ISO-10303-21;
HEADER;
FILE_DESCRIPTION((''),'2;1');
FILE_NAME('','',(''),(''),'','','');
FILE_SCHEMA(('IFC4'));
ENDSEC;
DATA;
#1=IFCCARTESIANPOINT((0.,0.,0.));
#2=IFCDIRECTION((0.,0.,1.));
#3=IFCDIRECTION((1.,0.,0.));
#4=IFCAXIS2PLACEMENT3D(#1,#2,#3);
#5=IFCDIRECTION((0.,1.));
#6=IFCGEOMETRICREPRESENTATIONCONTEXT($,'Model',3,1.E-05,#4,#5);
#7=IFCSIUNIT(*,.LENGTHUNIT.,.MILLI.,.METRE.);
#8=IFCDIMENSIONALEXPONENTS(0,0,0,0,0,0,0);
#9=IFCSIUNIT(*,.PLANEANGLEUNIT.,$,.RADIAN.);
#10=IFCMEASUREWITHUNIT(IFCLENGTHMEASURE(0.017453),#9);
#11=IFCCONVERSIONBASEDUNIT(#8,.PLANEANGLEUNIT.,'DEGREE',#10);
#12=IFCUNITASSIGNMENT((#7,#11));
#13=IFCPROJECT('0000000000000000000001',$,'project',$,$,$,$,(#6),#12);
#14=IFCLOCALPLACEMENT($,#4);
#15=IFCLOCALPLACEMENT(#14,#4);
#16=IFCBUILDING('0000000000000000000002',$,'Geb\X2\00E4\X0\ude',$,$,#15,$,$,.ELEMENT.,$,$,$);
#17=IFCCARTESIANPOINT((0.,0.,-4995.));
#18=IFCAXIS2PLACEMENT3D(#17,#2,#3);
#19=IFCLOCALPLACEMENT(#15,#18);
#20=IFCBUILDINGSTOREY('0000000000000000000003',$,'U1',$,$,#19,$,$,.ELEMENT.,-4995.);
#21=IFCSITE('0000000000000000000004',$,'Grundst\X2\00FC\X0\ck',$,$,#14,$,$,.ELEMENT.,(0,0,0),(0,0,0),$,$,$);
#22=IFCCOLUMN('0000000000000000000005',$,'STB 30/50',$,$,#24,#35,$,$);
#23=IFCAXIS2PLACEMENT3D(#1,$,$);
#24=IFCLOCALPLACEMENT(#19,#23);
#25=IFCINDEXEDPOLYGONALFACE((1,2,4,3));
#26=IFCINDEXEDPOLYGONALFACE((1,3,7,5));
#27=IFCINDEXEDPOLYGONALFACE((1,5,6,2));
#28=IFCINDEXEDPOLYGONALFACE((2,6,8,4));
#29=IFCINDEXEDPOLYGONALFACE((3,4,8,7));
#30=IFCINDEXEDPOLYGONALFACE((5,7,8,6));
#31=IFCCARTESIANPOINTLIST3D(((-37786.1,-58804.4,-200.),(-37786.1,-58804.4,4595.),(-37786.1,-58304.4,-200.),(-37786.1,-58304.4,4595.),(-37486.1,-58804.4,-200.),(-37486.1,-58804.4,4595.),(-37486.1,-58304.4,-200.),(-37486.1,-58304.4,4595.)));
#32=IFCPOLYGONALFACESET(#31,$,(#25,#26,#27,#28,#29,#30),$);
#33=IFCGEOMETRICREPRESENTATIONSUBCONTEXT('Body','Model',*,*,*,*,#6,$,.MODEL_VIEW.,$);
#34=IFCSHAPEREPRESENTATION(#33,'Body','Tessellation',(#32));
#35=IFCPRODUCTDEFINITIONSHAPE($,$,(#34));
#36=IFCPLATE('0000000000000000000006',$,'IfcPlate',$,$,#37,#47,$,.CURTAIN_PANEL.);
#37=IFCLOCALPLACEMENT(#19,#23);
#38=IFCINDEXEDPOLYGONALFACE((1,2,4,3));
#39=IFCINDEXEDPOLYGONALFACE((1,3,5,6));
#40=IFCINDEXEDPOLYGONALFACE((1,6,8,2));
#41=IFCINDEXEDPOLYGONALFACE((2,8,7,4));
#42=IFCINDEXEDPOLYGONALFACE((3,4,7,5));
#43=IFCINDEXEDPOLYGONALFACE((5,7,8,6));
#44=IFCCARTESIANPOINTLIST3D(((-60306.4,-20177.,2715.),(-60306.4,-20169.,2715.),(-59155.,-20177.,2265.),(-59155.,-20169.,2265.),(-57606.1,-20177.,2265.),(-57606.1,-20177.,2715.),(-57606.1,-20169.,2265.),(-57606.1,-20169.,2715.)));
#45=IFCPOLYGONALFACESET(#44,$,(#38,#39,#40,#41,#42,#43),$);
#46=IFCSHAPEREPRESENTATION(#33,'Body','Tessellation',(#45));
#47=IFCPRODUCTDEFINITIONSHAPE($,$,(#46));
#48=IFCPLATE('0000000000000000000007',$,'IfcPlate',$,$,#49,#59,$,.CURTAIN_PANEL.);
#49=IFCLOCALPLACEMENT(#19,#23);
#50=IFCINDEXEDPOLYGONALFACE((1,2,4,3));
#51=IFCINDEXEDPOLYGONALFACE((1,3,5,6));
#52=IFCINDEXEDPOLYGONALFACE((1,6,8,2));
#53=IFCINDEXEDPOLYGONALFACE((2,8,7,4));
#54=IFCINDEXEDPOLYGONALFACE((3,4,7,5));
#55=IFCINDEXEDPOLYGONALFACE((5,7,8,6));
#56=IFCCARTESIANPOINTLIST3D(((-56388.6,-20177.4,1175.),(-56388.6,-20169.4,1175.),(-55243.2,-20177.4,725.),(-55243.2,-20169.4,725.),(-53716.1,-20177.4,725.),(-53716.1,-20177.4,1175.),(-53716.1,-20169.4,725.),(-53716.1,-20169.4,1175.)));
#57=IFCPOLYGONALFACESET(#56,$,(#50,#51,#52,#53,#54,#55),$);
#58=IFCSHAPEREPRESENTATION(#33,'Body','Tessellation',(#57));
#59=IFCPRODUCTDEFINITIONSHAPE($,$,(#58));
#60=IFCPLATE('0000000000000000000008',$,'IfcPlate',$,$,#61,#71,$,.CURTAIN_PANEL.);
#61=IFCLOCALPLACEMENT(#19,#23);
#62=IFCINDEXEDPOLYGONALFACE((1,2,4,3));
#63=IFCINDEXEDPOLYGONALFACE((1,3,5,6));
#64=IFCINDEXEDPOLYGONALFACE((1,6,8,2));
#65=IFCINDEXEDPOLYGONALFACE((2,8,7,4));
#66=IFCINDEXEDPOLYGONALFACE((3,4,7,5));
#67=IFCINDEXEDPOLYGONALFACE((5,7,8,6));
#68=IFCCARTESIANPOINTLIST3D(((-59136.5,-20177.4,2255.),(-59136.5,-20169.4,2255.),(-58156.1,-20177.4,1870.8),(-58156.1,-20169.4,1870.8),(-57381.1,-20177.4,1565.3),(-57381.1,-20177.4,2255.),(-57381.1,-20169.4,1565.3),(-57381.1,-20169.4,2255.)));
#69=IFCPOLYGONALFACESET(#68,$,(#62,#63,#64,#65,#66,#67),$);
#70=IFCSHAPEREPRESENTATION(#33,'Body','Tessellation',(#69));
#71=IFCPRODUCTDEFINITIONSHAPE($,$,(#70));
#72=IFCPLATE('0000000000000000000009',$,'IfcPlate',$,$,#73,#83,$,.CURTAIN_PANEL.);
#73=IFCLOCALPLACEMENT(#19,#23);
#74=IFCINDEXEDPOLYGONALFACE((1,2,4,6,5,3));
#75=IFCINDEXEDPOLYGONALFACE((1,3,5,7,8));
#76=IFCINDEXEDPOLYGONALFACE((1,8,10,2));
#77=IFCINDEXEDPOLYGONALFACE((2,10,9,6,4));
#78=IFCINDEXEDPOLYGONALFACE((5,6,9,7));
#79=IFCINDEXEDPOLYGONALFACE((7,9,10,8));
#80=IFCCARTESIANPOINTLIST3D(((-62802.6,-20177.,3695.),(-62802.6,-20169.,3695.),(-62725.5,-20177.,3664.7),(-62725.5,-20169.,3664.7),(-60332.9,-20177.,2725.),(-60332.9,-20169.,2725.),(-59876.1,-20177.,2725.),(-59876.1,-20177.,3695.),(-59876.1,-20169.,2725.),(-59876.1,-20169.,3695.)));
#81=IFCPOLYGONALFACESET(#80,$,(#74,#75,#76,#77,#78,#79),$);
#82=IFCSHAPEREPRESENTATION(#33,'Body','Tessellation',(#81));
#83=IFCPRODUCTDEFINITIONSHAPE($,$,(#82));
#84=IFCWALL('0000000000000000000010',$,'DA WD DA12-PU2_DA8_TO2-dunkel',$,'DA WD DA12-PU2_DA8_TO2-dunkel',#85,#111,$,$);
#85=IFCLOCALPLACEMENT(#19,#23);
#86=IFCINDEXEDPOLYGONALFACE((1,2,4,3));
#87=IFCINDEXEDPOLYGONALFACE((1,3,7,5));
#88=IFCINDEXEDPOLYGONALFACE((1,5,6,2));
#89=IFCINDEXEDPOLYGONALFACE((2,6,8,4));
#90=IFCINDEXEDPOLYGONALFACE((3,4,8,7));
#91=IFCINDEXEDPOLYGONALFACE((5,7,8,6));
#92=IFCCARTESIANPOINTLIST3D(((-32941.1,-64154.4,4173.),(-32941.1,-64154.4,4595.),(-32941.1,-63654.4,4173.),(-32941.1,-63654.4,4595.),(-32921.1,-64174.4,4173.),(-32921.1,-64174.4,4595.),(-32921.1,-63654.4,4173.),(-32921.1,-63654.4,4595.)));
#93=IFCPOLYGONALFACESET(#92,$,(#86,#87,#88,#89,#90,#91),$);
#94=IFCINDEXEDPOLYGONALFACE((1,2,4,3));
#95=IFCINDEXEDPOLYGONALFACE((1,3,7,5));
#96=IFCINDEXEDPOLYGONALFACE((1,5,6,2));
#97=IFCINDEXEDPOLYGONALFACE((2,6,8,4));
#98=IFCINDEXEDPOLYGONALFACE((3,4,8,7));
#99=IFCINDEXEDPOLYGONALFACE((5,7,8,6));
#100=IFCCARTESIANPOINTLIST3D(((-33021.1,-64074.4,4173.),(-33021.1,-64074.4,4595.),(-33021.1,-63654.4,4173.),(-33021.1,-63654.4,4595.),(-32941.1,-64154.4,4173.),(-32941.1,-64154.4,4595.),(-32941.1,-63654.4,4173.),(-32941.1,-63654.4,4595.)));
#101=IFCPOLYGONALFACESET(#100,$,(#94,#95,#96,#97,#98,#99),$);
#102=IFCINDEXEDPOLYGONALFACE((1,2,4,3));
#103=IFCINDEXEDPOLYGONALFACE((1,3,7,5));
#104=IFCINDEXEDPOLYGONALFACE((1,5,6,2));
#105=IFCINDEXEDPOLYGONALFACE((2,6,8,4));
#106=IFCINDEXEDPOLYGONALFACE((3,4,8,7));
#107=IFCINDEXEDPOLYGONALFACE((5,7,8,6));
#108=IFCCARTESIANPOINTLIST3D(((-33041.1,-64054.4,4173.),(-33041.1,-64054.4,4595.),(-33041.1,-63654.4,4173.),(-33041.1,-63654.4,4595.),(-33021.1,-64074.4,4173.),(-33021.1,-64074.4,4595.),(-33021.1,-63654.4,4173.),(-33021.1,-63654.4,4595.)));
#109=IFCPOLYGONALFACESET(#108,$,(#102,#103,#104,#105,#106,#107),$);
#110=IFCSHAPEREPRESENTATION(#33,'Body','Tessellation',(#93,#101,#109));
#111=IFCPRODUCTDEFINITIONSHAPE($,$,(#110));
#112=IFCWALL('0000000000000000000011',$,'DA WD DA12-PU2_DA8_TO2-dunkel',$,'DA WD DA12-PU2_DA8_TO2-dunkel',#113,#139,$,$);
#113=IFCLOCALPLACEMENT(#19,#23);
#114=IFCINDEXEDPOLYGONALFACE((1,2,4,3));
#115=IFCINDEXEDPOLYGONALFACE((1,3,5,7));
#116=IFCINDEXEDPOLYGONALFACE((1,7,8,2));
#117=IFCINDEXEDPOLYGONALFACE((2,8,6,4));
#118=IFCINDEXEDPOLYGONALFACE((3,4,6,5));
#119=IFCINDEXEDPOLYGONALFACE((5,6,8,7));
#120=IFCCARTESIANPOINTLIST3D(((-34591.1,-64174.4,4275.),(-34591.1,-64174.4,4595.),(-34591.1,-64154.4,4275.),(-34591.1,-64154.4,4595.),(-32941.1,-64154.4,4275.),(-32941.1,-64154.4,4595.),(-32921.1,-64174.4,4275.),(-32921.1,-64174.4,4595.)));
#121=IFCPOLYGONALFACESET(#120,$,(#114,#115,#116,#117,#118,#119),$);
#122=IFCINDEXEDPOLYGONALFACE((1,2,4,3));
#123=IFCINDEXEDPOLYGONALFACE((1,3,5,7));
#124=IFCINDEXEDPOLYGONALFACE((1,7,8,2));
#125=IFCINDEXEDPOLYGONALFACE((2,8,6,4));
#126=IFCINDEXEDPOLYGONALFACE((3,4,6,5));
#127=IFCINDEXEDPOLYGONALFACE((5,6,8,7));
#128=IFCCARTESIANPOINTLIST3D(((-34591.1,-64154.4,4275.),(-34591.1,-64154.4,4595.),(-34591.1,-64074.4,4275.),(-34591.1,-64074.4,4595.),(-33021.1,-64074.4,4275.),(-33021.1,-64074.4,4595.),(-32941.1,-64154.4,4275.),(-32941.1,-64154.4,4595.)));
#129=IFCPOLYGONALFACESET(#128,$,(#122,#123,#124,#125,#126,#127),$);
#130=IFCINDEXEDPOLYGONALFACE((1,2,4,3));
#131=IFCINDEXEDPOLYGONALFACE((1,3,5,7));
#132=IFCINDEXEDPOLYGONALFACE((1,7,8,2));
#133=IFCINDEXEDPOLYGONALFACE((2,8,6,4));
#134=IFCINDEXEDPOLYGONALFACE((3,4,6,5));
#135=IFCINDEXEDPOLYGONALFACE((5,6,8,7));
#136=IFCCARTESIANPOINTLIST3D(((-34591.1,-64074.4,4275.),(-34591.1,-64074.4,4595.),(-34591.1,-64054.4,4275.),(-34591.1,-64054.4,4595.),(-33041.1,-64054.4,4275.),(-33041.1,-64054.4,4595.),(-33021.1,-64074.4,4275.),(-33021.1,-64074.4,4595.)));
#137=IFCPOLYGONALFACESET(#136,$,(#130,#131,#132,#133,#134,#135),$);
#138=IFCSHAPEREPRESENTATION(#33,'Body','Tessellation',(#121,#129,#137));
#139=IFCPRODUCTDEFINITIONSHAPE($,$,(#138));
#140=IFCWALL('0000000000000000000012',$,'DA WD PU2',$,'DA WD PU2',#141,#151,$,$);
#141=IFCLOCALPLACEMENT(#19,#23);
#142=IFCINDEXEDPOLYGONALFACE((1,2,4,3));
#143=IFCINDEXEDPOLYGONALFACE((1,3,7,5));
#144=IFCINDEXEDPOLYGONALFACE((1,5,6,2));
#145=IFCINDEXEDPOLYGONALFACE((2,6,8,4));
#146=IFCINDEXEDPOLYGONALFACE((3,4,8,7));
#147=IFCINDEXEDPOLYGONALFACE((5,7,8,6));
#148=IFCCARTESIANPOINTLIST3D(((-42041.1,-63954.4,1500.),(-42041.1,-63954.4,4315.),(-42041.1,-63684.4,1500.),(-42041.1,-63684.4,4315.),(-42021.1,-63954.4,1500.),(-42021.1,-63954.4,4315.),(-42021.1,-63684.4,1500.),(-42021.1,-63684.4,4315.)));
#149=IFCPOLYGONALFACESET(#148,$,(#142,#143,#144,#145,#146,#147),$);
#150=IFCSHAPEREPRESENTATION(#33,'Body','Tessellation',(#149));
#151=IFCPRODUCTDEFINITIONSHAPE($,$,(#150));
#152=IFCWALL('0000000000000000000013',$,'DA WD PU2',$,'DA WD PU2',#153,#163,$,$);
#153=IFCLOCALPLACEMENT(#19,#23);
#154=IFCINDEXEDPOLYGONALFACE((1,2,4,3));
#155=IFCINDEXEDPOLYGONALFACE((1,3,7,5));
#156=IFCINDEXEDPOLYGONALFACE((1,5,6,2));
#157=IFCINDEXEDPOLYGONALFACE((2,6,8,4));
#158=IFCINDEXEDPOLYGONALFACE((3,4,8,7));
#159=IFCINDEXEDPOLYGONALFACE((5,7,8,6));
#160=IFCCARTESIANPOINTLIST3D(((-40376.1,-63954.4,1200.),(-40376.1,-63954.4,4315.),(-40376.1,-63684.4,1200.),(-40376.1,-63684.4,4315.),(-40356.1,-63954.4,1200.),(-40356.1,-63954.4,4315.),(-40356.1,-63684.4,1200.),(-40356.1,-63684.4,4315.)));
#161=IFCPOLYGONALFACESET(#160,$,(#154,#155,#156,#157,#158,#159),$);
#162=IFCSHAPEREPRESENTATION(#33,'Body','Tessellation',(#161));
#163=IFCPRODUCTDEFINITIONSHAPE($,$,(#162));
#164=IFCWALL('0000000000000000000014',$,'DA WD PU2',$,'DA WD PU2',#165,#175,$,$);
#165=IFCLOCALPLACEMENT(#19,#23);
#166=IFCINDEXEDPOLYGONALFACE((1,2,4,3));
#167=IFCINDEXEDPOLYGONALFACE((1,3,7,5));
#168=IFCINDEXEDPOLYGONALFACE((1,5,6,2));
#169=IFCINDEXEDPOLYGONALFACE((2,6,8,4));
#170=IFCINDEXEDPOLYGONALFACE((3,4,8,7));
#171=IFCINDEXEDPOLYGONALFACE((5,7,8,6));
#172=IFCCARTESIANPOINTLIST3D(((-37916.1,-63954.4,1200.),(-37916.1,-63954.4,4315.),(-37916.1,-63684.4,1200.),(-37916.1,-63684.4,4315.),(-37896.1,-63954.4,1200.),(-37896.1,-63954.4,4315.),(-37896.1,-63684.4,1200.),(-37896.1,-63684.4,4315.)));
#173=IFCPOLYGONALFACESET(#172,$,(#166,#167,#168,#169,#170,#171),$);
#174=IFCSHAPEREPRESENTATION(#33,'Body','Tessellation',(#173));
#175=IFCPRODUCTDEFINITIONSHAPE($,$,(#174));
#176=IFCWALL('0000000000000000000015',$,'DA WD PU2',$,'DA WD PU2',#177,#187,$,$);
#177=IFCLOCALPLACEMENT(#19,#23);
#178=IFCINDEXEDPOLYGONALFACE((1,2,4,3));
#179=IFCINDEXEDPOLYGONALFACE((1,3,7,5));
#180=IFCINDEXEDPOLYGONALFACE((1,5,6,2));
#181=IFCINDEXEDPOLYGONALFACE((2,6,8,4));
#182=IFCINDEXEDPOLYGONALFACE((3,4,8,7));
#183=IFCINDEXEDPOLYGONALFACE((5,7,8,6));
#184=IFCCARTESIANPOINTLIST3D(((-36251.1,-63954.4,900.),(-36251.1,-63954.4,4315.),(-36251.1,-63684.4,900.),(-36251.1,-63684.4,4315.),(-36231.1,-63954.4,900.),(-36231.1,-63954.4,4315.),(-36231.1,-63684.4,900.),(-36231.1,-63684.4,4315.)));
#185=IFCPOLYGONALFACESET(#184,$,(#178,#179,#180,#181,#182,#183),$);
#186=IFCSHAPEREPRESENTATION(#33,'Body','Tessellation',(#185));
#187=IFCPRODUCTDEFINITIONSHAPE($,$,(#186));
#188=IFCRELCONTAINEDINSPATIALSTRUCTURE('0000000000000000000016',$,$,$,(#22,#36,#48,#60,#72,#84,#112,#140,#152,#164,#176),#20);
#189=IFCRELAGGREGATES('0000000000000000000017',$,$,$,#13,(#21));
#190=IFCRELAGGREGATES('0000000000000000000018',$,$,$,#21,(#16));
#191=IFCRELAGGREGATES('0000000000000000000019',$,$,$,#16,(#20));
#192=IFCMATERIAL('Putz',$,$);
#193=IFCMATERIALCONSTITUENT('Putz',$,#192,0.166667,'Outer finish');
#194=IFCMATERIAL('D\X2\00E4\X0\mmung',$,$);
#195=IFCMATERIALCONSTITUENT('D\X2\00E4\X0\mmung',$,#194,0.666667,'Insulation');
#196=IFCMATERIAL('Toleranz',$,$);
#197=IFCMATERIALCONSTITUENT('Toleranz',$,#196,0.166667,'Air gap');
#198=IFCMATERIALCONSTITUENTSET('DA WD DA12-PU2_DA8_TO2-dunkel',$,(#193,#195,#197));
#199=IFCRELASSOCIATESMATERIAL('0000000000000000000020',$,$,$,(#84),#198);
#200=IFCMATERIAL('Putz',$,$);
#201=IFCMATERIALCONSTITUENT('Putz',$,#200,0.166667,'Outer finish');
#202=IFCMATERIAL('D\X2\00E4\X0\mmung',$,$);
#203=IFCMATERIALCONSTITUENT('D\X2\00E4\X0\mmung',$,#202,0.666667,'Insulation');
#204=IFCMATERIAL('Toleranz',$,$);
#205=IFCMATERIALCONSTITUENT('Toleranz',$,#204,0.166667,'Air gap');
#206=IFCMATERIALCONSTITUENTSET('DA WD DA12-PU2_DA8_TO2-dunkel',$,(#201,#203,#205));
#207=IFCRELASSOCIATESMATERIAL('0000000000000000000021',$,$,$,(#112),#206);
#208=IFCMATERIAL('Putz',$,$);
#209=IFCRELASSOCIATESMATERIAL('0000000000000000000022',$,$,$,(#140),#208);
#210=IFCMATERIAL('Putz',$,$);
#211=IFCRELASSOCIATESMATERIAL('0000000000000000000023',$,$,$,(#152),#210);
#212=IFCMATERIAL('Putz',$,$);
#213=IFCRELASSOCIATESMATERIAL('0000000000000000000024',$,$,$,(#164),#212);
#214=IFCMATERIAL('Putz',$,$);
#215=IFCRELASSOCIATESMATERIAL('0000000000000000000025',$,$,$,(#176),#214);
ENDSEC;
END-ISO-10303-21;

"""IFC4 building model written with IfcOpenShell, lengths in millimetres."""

from ifc_helpers import new_model, entity, si_unit, converted_unit, direction, frame, origin_with_axes, place, context, subcontext, project, spatial, line, indexed_curve, outline, extrude, material, constituent, constituent_set, element, save


model = new_model("IFC4")

# Units and contexts
model_context = context("Model", 3, precision=1e-05, world=origin_with_axes(), true_north=direction((0.0, 1.0)))
body_context = subcontext(model_context, "Body", "Model", "MODEL_VIEW")
ifc_project = project(units=[si_unit("LENGTHUNIT", "METRE", prefix="MILLI"), converted_unit("PLANEANGLEUNIT", "DEGREE", entity("IfcLengthMeasure", 0.017453), si_unit("PLANEANGLEUNIT", "RADIAN"), dimensions=[0, 0, 0, 0, 0, 0, 0])], contexts=[model_context])

# Site, building, storey
site_placement = place(None, origin_with_axes())
site = spatial("IfcSite", under=ifc_project, at=site_placement, Name="Grundstück", CompositionType="ELEMENT", RefLatitude=(0, 0, 0), RefLongitude=(0, 0, 0))
building_placement = place(site_placement, origin_with_axes())
building = spatial("IfcBuilding", under=site, at=building_placement, Name="Gebäude", CompositionType="ELEMENT")
storey_placement = place(building_placement, frame((0.0, 0.0, -4995.0), z_axis=(0.0, 0.0, 1.0), x_axis=(1.0, 0.0, 0.0)))
storey = spatial("IfcBuildingStorey", under=building, at=storey_placement, Name="U1", CompositionType="ELEMENT", Elevation=-4995.0)

# Column
column_placement = place(storey_placement, frame((-37636.1, -58554.4, -200.0), z_axis=(0.0, 0.0, 1.0), x_axis=(1.0, 0.0, 0.0)))
element("IfcColumn", 1, at=column_placement, inside=storey, Name="STB 30/50", context=body_context, shape_type="SweptSolid", body=[
    extrude(outline(indexed_curve([(-150.0, -250.0), (150.0, -250.0), (150.0, 250.0), (-150.0, 250.0)], segments=[line(1, 2), line(2, 3), line(3, 4), line(4, 1)])), origin_with_axes(), (0.0, 0.0, 1.0), 4795.0),
])

# Plates
plate_1_placement = place(storey_placement, frame((0.0, -20169.0, 0.0), z_axis=(0.0, 1.0, 0.0), x_axis=(-1.0, 0.0, 0.0)))
element("IfcPlate", 2, at=plate_1_placement, inside=storey, Name="IfcPlate", PredefinedType="CURTAIN_PANEL", context=body_context, shape_type="SweptSolid", body=[
    extrude(outline(indexed_curve([(57606.1, 2715.0), (57606.1, 2265.0), (59155.0, 2265.0), (60306.4, 2715.0)], segments=[line(1, 2), line(2, 3), line(3, 4), line(4, 1)])), origin_with_axes(), (0.0, 0.0, -1.0), 8.0),
])
plate_2_placement = place(storey_placement, frame((0.0, -20177.4, 0.0), z_axis=(0.0, 1.0, 0.0), x_axis=(-1.0, 0.0, 0.0)))
element("IfcPlate", 3, at=plate_2_placement, inside=storey, Name="IfcPlate", PredefinedType="CURTAIN_PANEL", context=body_context, shape_type="SweptSolid", body=[
    extrude(outline(indexed_curve([(55243.2, 725.0), (56388.6, 1175.0), (53716.1, 1175.0), (53716.1, 725.0)], segments=[line(1, 2), line(2, 3), line(3, 4), line(4, 1)])), origin_with_axes(), (0.0, 0.0, 1.0), 8.0),
])
plate_3_placement = place(storey_placement, frame((0.0, -20169.4, 0.0), z_axis=(0.0, 1.0, 0.0), x_axis=(-1.0, 0.0, 0.0)))
element("IfcPlate", 4, at=plate_3_placement, inside=storey, Name="IfcPlate", PredefinedType="CURTAIN_PANEL", context=body_context, shape_type="SweptSolid", body=[
    extrude(outline(indexed_curve([(57381.1, 1565.3), (57381.1, 2255.0), (59136.5, 2255.0), (58156.1, 1870.8)], segments=[line(1, 2), line(2, 3), line(3, 4), line(4, 1)])), origin_with_axes(), (0.0, 0.0, -1.0), 8.0),
])
plate_4_placement = place(storey_placement, frame((0.0, -20169.0, 0.0), z_axis=(0.0, 1.0, 0.0), x_axis=(-1.0, 0.0, 0.0)))
element("IfcPlate", 5, at=plate_4_placement, inside=storey, Name="IfcPlate", PredefinedType="CURTAIN_PANEL", context=body_context, shape_type="SweptSolid", body=[
    extrude(outline(indexed_curve([(59876.1, 2725.0), (59876.1, 3695.0), (62802.6, 3695.0), (62725.5, 3664.7), (60332.9, 2725.0)], segments=[line(1, 2), line(2, 3), line(3, 4), line(4, 5), line(5, 1)])), origin_with_axes(), (0.0, 0.0, -1.0), 8.0),
])

# Walls
ifc_material_1 = material(Name="Putz")
ifc_constituent_1 = constituent(ifc_material_1, Name="Putz", Category="Outer finish", fraction=0.166667)
ifc_material_2 = material(Name="Dämmung")
ifc_constituent_2 = constituent(ifc_material_2, Name="Dämmung", Category="Insulation", fraction=0.666667)
ifc_material_3 = material(Name="Toleranz")
ifc_constituent_3 = constituent(ifc_material_3, Name="Toleranz", Category="Air gap", fraction=0.166667)
ifc_constituent_set_1 = constituent_set(constituents=[ifc_constituent_1, ifc_constituent_2, ifc_constituent_3], Name="DA WD DA12-PU2_DA8_TO2-dunkel")
wall_1_placement = place(storey_placement, frame((-32981.1, -63654.4, 4173.0), z_axis=(0.0, 0.0, 1.0), x_axis=(0.0, -1.0, 0.0)))
element("IfcWall", 6, at=wall_1_placement, inside=storey, material=ifc_constituent_set_1, Name="DA WD DA12-PU2_DA8_TO2-dunkel", ObjectType="DA WD DA12-PU2_DA8_TO2-dunkel", context=body_context, shape_type="SweptSolid", body=[
    extrude(outline(indexed_curve([(520.0, 60.0), (500.0, 40.0), (0.0, 40.0), (0.0, 60.0)], segments=[line(1, 2), line(2, 3), line(3, 4), line(4, 1)])), origin_with_axes(), (0.0, 0.0, 1.0), 422.0),
    extrude(outline(indexed_curve([(0.0, 40.0), (500.0, 40.0), (420.0, -40.0), (0.0, -40.0)], segments=[line(1, 2), line(2, 3), line(3, 4), line(4, 1)])), origin_with_axes(), (0.0, 0.0, 1.0), 422.0),
    extrude(outline(indexed_curve([(420.0, -40.0), (400.0, -60.0), (0.0, -60.0), (0.0, -40.0)], segments=[line(1, 2), line(2, 3), line(3, 4), line(4, 1)])), origin_with_axes(), (0.0, 0.0, 1.0), 422.0),
])
ifc_material_4 = material(Name="Putz")
ifc_constituent_4 = constituent(ifc_material_4, Name="Putz", Category="Outer finish", fraction=0.166667)
ifc_material_5 = material(Name="Dämmung")
ifc_constituent_5 = constituent(ifc_material_5, Name="Dämmung", Category="Insulation", fraction=0.666667)
ifc_material_6 = material(Name="Toleranz")
ifc_constituent_6 = constituent(ifc_material_6, Name="Toleranz", Category="Air gap", fraction=0.166667)
ifc_constituent_set_2 = constituent_set(constituents=[ifc_constituent_4, ifc_constituent_5, ifc_constituent_6], Name="DA WD DA12-PU2_DA8_TO2-dunkel")
wall_2_placement = place(storey_placement, frame((-32981.1, -64114.4, 4275.0), z_axis=(0.0, 0.0, 1.0), x_axis=(-1.0, 0.0, 0.0)))
element("IfcWall", 7, at=wall_2_placement, inside=storey, material=ifc_constituent_set_2, Name="DA WD DA12-PU2_DA8_TO2-dunkel", ObjectType="DA WD DA12-PU2_DA8_TO2-dunkel", context=body_context, shape_type="SweptSolid", body=[
    extrude(outline(indexed_curve([(1610.0, 60.0), (1610.0, 40.0), (-40.0, 40.0), (-60.0, 60.0)], segments=[line(1, 2), line(2, 3), line(3, 4), line(4, 1)])), origin_with_axes(), (0.0, 0.0, 1.0), 320.0),
    extrude(outline(indexed_curve([(1610.0, 40.0), (1610.0, -40.0), (40.0, -40.0), (-40.0, 40.0)], segments=[line(1, 2), line(2, 3), line(3, 4), line(4, 1)])), origin_with_axes(), (0.0, 0.0, 1.0), 320.0),
    extrude(outline(indexed_curve([(40.0, -40.0), (1610.0, -40.0), (1610.0, -60.0), (60.0, -60.0)], segments=[line(1, 2), line(2, 3), line(3, 4), line(4, 1)])), origin_with_axes(), (0.0, 0.0, 1.0), 320.0),
])
ifc_material_7 = material(Name="Putz")
wall_3_placement = place(storey_placement, frame((-42031.1, -63954.4, 1500.0), z_axis=(0.0, 0.0, 1.0), x_axis=(0.0, 1.0, 0.0)))
element("IfcWall", 8, at=wall_3_placement, inside=storey, material=ifc_material_7, Name="DA WD PU2", ObjectType="DA WD PU2", context=body_context, shape_type="SweptSolid", body=[
    extrude(outline(indexed_curve([(0.0, -10.0), (0.0, 10.0), (270.0, 10.0), (270.0, -10.0)], segments=[line(1, 2), line(2, 3), line(3, 4), line(4, 1)])), origin_with_axes(), (0.0, 0.0, 1.0), 2815.0),
])
ifc_material_8 = material(Name="Putz")
wall_4_placement = place(storey_placement, frame((-40366.1, -63954.4, 1200.0), z_axis=(0.0, 0.0, 1.0), x_axis=(0.0, 1.0, 0.0)))
element("IfcWall", 9, at=wall_4_placement, inside=storey, material=ifc_material_8, Name="DA WD PU2", ObjectType="DA WD PU2", context=body_context, shape_type="SweptSolid", body=[
    extrude(outline(indexed_curve([(0.0, -10.0), (0.0, 10.0), (270.0, 10.0), (270.0, -10.0)], segments=[line(1, 2), line(2, 3), line(3, 4), line(4, 1)])), origin_with_axes(), (0.0, 0.0, 1.0), 3115.0),
])
ifc_material_9 = material(Name="Putz")
wall_5_placement = place(storey_placement, frame((-37906.1, -63954.4, 1200.0), z_axis=(0.0, 0.0, 1.0), x_axis=(0.0, 1.0, 0.0)))
element("IfcWall", 10, at=wall_5_placement, inside=storey, material=ifc_material_9, Name="DA WD PU2", ObjectType="DA WD PU2", context=body_context, shape_type="SweptSolid", body=[
    extrude(outline(indexed_curve([(0.0, -10.0), (0.0, 10.0), (270.0, 10.0), (270.0, -10.0)], segments=[line(1, 2), line(2, 3), line(3, 4), line(4, 1)])), origin_with_axes(), (0.0, 0.0, 1.0), 3115.0),
])
ifc_material_10 = material(Name="Putz")
wall_6_placement = place(storey_placement, frame((-36241.1, -63954.4, 900.0), z_axis=(0.0, 0.0, 1.0), x_axis=(0.0, 1.0, 0.0)))
element("IfcWall", 11, at=wall_6_placement, inside=storey, material=ifc_material_10, Name="DA WD PU2", ObjectType="DA WD PU2", context=body_context, shape_type="SweptSolid", body=[
    extrude(outline(indexed_curve([(0.0, -10.0), (0.0, 10.0), (270.0, 10.0), (270.0, -10.0)], segments=[line(1, 2), line(2, 3), line(3, 4), line(4, 1)])), origin_with_axes(), (0.0, 0.0, 1.0), 3415.0),
])

save(model, "model.ifc")
